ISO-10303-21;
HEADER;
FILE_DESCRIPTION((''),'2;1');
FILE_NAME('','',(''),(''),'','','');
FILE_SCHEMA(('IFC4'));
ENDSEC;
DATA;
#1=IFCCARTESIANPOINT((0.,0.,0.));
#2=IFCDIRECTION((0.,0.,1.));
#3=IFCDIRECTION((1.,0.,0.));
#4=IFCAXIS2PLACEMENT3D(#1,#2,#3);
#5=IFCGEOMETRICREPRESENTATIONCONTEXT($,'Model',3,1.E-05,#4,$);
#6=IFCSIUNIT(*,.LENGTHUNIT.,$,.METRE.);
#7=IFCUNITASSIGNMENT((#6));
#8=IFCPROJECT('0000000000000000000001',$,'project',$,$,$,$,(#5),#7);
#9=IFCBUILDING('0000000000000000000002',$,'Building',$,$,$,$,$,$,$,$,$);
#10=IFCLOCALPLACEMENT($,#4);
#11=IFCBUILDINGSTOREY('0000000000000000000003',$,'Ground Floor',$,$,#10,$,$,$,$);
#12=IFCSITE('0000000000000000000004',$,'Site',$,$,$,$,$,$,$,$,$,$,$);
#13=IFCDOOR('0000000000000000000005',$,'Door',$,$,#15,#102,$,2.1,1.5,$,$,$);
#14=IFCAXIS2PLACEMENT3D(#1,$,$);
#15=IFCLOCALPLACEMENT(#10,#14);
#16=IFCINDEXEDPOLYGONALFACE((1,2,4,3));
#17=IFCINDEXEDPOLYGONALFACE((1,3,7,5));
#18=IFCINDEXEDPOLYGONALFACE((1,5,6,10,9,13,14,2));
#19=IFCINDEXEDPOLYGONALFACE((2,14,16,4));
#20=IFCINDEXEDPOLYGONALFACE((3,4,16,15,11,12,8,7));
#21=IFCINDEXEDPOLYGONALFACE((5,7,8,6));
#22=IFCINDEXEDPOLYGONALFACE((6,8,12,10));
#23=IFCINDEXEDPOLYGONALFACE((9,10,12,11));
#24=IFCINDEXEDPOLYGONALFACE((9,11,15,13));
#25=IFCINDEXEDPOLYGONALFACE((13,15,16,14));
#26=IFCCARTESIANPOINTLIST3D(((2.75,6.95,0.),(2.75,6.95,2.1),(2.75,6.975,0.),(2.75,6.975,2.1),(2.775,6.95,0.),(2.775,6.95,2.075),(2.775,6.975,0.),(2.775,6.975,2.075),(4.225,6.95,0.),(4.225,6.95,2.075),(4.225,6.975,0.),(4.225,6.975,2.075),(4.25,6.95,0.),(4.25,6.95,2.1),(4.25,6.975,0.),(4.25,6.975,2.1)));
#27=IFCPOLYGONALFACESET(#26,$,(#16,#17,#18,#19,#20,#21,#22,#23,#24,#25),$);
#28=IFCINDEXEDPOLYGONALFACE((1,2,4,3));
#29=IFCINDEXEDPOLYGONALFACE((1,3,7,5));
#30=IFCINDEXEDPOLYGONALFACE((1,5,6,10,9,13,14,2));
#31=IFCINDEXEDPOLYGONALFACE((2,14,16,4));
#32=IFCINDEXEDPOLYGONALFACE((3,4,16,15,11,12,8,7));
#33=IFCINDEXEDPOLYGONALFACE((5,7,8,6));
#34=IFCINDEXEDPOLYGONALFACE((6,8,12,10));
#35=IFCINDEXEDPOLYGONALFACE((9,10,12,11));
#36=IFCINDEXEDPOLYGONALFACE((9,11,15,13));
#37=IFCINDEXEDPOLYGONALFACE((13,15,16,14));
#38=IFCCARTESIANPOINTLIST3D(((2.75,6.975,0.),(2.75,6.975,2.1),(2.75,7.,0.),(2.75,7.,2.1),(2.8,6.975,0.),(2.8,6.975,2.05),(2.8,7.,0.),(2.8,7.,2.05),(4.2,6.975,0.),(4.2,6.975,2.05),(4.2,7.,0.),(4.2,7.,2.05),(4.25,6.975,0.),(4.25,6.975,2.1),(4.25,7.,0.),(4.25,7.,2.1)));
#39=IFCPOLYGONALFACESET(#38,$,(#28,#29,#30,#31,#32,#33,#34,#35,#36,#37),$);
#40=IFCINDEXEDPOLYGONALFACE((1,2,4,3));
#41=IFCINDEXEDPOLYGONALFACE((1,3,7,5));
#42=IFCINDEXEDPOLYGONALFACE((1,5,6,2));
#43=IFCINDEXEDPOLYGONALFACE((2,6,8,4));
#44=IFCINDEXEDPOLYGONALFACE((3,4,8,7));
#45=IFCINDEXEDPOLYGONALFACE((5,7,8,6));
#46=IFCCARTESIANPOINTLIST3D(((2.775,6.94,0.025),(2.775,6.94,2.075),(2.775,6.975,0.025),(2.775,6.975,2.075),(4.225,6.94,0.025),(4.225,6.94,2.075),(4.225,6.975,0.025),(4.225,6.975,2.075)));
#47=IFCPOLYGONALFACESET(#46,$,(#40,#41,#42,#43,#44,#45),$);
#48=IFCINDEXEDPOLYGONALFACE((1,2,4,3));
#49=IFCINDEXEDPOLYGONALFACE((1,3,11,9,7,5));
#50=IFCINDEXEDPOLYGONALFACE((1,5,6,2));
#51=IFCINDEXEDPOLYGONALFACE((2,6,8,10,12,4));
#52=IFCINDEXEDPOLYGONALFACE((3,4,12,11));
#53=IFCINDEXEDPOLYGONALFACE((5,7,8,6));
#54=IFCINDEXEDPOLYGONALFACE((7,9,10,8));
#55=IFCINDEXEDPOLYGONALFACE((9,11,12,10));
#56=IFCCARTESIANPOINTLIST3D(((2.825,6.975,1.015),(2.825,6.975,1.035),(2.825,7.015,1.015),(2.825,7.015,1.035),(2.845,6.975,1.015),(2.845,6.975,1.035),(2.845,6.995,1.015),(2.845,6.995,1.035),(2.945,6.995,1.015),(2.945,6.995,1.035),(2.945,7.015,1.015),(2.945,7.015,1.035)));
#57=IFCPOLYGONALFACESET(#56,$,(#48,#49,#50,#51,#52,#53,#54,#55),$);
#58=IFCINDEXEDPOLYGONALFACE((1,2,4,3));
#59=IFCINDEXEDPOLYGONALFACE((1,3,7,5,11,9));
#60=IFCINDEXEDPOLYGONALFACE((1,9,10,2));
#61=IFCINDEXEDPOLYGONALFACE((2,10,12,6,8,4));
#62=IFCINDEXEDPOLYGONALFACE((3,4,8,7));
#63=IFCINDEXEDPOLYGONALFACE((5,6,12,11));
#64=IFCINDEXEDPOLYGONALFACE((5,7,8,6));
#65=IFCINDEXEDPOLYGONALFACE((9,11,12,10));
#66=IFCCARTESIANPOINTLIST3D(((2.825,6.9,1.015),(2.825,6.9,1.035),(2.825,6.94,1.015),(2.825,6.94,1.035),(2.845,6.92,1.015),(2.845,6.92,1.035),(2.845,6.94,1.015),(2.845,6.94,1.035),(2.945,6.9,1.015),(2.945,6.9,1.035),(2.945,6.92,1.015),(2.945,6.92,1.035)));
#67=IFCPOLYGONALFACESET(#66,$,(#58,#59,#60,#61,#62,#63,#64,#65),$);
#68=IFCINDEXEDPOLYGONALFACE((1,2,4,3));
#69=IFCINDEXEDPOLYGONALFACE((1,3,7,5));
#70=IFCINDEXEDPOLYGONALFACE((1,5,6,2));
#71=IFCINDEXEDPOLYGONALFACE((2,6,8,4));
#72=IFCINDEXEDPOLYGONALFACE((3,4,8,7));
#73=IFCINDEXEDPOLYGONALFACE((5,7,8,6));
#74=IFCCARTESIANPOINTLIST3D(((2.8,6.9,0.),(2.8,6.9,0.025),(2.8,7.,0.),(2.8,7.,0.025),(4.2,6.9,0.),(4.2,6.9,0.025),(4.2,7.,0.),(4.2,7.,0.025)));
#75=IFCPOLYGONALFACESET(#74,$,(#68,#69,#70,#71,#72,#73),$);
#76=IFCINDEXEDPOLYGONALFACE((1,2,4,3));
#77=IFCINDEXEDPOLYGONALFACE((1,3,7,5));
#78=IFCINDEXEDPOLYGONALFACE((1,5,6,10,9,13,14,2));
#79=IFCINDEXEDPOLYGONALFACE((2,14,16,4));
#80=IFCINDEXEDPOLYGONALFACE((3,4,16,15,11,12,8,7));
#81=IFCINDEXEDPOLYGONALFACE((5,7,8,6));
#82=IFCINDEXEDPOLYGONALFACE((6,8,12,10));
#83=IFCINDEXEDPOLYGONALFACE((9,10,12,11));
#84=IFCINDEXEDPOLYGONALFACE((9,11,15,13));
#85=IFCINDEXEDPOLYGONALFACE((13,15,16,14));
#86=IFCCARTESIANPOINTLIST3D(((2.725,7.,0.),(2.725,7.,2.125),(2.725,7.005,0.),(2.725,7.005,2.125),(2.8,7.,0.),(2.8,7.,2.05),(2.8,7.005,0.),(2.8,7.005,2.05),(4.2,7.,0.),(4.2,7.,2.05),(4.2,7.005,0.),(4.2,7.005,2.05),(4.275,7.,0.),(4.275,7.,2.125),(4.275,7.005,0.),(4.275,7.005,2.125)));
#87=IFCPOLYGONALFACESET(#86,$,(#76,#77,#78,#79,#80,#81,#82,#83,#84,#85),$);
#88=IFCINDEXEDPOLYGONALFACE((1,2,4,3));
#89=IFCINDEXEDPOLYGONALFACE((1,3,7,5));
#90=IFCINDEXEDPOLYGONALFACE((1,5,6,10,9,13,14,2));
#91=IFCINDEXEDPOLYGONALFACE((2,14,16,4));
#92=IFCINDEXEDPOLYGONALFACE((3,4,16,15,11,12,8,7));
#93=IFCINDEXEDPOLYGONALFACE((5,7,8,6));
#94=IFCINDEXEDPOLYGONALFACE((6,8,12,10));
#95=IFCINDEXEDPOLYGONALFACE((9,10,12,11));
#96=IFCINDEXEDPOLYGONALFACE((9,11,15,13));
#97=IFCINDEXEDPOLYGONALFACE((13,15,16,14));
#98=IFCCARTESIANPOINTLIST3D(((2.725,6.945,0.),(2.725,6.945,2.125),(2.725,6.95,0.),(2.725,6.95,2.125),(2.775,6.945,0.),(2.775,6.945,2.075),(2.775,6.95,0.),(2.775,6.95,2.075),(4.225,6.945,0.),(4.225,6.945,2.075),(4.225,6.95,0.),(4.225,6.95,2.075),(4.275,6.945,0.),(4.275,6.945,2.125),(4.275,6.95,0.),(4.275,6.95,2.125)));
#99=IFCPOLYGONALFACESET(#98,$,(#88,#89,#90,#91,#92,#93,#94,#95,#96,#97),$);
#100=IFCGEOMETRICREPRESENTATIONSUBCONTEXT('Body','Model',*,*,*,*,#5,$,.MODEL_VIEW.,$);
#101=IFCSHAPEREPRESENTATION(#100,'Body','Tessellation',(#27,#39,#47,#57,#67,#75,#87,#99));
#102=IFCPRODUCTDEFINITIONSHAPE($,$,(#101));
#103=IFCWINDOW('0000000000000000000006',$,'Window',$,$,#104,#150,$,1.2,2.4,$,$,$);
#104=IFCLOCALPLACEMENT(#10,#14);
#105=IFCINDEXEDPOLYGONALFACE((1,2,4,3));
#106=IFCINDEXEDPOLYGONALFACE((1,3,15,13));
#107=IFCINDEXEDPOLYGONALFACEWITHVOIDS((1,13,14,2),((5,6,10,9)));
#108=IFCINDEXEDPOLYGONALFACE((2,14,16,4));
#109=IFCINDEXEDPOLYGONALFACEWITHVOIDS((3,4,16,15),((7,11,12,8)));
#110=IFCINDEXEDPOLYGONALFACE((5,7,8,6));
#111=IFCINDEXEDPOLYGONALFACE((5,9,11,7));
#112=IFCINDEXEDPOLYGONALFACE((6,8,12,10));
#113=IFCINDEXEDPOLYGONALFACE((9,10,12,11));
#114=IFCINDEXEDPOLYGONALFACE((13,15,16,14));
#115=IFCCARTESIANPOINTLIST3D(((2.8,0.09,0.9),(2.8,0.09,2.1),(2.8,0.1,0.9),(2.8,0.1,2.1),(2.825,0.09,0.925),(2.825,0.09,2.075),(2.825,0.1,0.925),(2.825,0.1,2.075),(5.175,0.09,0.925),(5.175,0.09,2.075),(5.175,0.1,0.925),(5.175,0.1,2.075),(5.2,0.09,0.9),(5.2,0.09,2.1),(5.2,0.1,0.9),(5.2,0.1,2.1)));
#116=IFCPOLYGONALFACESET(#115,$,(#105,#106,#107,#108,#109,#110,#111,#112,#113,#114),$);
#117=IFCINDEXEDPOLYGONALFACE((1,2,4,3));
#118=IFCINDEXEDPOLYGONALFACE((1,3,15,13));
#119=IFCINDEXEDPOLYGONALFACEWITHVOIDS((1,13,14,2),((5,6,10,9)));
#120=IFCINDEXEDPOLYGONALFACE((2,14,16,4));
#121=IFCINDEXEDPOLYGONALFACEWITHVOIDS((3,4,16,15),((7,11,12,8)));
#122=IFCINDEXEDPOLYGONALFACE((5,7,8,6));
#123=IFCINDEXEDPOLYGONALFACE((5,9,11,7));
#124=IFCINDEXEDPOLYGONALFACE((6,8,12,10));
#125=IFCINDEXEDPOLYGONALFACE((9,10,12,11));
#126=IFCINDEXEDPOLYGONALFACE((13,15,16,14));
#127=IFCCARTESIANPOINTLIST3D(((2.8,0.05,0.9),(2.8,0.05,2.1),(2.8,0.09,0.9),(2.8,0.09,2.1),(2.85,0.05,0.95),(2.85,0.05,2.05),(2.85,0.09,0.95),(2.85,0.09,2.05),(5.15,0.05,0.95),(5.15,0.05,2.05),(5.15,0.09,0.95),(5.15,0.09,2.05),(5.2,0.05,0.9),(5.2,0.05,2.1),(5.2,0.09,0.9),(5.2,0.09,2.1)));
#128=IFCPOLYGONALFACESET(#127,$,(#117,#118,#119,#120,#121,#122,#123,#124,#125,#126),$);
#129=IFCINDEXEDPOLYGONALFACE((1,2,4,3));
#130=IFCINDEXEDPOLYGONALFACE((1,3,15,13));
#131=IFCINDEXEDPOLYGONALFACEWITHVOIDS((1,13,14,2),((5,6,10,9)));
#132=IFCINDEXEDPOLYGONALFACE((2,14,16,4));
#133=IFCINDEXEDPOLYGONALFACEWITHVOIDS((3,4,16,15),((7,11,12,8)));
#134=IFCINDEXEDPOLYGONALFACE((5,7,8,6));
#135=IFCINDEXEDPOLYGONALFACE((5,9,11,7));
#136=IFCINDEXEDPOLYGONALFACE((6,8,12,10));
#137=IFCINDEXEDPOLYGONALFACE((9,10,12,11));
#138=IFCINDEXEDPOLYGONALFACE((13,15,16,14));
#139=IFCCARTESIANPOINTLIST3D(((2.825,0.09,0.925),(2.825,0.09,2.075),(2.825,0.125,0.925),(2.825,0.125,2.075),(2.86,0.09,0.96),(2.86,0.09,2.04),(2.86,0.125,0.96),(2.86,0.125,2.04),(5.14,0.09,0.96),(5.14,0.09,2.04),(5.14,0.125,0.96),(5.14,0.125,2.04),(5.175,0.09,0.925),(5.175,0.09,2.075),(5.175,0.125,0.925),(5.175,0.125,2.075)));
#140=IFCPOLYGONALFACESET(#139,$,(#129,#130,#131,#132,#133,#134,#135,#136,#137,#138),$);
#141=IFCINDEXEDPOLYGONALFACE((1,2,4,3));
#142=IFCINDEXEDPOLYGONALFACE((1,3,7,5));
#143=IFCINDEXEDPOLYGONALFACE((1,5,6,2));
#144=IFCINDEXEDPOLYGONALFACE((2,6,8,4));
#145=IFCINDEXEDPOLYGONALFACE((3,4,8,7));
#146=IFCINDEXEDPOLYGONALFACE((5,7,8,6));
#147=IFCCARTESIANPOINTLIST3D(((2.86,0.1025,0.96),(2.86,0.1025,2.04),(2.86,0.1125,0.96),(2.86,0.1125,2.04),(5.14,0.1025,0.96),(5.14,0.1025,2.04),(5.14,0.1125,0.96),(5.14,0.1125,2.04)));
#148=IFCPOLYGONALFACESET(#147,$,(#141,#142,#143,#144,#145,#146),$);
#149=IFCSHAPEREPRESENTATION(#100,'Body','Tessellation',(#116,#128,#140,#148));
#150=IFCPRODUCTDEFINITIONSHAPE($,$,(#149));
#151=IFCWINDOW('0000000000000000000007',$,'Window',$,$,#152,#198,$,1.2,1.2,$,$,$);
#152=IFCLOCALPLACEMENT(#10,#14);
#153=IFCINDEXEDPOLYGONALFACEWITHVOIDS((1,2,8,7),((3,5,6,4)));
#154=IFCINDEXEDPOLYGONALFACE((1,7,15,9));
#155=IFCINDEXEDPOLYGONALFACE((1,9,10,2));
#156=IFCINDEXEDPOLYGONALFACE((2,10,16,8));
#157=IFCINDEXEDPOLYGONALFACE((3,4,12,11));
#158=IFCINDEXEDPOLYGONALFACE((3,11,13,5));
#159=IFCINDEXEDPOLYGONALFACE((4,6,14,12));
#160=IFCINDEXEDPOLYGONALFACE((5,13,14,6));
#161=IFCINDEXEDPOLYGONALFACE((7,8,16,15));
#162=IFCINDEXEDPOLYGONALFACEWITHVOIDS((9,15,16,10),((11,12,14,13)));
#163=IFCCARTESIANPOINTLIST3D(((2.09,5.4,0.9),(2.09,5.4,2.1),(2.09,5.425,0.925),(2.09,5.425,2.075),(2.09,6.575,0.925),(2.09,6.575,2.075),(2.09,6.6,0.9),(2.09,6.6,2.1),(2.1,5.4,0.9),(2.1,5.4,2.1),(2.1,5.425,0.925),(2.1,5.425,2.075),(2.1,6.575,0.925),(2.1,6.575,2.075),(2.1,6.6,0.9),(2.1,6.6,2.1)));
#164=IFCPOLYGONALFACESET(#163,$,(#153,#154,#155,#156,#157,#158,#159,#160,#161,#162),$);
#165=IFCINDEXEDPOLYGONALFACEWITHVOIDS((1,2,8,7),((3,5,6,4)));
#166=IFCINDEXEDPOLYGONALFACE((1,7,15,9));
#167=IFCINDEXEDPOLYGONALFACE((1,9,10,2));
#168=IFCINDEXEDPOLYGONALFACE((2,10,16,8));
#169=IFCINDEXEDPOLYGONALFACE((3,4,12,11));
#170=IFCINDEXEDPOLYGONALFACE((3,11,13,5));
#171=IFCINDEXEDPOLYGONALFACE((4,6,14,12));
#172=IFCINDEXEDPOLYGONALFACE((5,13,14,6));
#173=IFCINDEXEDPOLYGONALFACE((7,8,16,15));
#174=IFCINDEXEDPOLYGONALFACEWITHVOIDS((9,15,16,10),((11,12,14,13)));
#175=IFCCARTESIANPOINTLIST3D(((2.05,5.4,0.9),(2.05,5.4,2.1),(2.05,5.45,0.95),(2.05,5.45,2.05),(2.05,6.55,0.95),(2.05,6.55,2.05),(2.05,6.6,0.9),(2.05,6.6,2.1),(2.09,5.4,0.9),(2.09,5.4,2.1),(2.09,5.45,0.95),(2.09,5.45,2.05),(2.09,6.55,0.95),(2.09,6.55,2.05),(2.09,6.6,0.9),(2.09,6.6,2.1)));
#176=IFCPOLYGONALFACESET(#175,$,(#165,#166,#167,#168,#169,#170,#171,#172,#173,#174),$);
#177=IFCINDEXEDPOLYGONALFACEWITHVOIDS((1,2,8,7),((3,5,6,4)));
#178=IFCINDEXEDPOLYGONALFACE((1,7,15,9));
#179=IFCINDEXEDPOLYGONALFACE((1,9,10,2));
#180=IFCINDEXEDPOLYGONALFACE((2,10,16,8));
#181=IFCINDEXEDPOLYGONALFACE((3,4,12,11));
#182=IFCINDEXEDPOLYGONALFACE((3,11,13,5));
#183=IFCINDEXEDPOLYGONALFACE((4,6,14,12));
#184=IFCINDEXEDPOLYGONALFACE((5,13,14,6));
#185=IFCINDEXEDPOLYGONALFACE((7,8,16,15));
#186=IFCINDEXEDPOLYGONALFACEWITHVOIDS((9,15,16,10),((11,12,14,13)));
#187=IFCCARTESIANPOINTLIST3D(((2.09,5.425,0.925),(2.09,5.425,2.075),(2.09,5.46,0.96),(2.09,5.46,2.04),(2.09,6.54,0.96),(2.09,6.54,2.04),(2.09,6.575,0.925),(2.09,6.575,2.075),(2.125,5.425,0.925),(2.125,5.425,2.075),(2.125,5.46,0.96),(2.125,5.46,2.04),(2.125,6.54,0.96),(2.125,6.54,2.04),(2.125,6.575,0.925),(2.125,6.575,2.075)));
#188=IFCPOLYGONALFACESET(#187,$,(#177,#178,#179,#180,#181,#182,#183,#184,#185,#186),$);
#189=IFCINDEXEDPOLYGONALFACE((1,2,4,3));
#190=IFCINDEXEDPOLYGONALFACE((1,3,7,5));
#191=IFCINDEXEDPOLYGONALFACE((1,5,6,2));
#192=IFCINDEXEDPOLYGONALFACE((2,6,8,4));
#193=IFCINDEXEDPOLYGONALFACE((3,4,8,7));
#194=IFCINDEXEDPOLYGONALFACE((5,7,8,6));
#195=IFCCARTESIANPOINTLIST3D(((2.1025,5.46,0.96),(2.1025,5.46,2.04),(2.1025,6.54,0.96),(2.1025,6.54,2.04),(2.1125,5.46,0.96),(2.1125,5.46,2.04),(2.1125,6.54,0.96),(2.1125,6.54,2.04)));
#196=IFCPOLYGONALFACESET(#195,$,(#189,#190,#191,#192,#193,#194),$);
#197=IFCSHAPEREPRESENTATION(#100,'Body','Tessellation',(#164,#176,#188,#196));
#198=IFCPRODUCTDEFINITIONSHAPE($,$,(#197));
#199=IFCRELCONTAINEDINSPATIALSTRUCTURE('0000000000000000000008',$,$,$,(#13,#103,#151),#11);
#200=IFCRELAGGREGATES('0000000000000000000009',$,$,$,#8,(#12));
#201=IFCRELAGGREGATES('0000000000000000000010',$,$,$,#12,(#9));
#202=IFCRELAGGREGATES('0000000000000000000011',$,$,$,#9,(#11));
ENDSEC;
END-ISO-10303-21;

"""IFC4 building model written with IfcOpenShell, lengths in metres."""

from ifc_helpers import new_model, si_unit, frame, origin_with_axes, place, context, subcontext, project, spatial, line, indexed_curve, outline, extrude, element, save


model = new_model("IFC4")

# Units and contexts
model_context = context("Model", 3, precision=1e-05, world=origin_with_axes())
body_context = subcontext(model_context, "Body", "Model", "MODEL_VIEW")
ifc_project = project(units=[si_unit("LENGTHUNIT", "METRE")], contexts=[model_context])

# Site, building, storey
site = spatial("IfcSite", under=ifc_project, Name="Site")
building = spatial("IfcBuilding", under=site, Name="Building")
storey_placement = place(None, origin_with_axes())
storey = spatial("IfcBuildingStorey", under=building, at=storey_placement, Name="Ground Floor")

# Door
door_1_placement = place(storey_placement, frame((4.25, 7.0, 0.0), z_axis=(0.0, 0.0, 1.0), x_axis=(-1.0, 0.0, 0.0)))
element("IfcDoor", 1, at=door_1_placement, inside=storey, Name="Door", OverallHeight=2.1, OverallWidth=1.5, context=body_context, shape_type="SweptSolid", body=[
    extrude(outline(indexed_curve([(0.0, 0.0), (0.0, 2.1), (1.5, 2.1), (1.5, 0.0), (1.475, 0.0), (1.475, 2.075), (0.025, 2.075), (0.025, 0.0)], segments=[line(1, 2, 3, 4, 5, 6, 7, 8, 1)])), frame((0.0, 0.025, 0.0), z_axis=(0.0, -1.0, 0.0), x_axis=(1.0, 0.0, 0.0)), (0.0, 0.0, -1.0), 0.025),
    extrude(outline(indexed_curve([(0.0, 0.0), (0.0, 2.1), (1.5, 2.1), (1.5, 0.0), (1.45, 0.0), (1.45, 2.05), (0.05, 2.05), (0.05, 0.0)], segments=[line(1, 2, 3, 4, 5, 6, 7, 8, 1)])), frame((0.0, 0.0, 0.0), z_axis=(0.0, -1.0, 0.0), x_axis=(1.0, 0.0, 0.0)), (0.0, 0.0, -1.0), 0.025),
    extrude(outline(indexed_curve([(0.0, 0.0), (1.45, 0.0), (1.45, 0.035), (0.0, 0.035)], segments=[line(1, 2, 3, 4, 1)])), frame((0.025, 0.025, 0.025), z_axis=(0.0, 0.0, 1.0), x_axis=(1.0, 0.0, 0.0)), (0.0, 0.0, 1.0), 2.05),
    extrude(outline(indexed_curve([(0.0, 0.0), (0.0, -0.04), (-0.12, -0.04), (-0.12, -0.02), (-0.02, -0.02), (-0.02, 0.0)], segments=[line(1, 2, 3, 4, 5, 6, 1)])), frame((1.425, 0.025, 1.015), z_axis=(0.0, 0.0, 1.0), x_axis=(1.0, 0.0, 0.0)), (0.0, 0.0, 1.0), 0.02),
    extrude(outline(indexed_curve([(0.0, 0.0), (0.0, 0.04), (-0.12, 0.04), (-0.12, 0.02), (-0.02, 0.02), (-0.02, 0.0)], segments=[line(1, 2, 3, 4, 5, 6, 1)])), frame((1.425, 0.06, 1.015), z_axis=(0.0, 0.0, 1.0), x_axis=(1.0, 0.0, 0.0)), (0.0, 0.0, 1.0), 0.02),
    extrude(outline(indexed_curve([(0.0, 0.0), (1.4, 0.0), (1.4, 0.1), (0.0, 0.1)], segments=[line(1, 2, 3, 4, 1)])), frame((0.05, 0.0, 0.0), z_axis=(0.0, 0.0, 1.0), x_axis=(1.0, 0.0, 0.0)), (0.0, 0.0, 1.0), 0.025),
    extrude(outline(indexed_curve([(0.0, 0.0), (0.0, 2.125), (1.55, 2.125), (1.55, 0.0), (1.475, 0.0), (1.475, 2.05), (0.075, 2.05), (0.075, 0.0)], segments=[line(1, 2, 3, 4, 5, 6, 7, 8, 1)])), frame((-0.025, -0.005, 0.0), z_axis=(0.0, -1.0, 0.0), x_axis=(1.0, 0.0, 0.0)), (0.0, 0.0, -1.0), 0.005),
    extrude(outline(indexed_curve([(0.0, 0.0), (0.0, 2.125), (1.55, 2.125), (1.55, 0.0), (1.5, 0.0), (1.5, 2.075), (0.05, 2.075), (0.05, 0.0)], segments=[line(1, 2, 3, 4, 5, 6, 7, 8, 1)])), frame((-0.025, 0.05, 0.0), z_axis=(0.0, -1.0, 0.0), x_axis=(1.0, 0.0, 0.0)), (0.0, 0.0, -1.0), 0.005),
])

# Windows
window_1_placement = place(storey_placement, frame((2.8, 0.0, 0.9), z_axis=(0.0, 0.0, 1.0), x_axis=(1.0, 0.0, 0.0)))
element("IfcWindow", 2, at=window_1_placement, inside=storey, Name="Window", OverallHeight=1.2, OverallWidth=2.4, context=body_context, shape_type="SweptSolid", body=[
    extrude(outline(indexed_curve([(0.0, 0.0), (2.4, 0.0), (2.4, 1.2), (0.0, 1.2)], segments=[line(1, 2, 3, 4, 1)]), holes=[indexed_curve([(0.025, 0.025), (2.375, 0.025), (2.375, 1.175), (0.025, 1.175)], segments=[line(1, 2, 3, 4, 1)])]), frame((0.0, 0.09, 0.0), z_axis=(0.0, -1.0, 0.0), x_axis=(1.0, 0.0, 0.0)), (0.0, 0.0, -1.0), 0.01),
    extrude(outline(indexed_curve([(0.0, 0.0), (2.4, 0.0), (2.4, 1.2), (0.0, 1.2)], segments=[line(1, 2, 3, 4, 1)]), holes=[indexed_curve([(0.05, 0.05), (2.35, 0.05), (2.35, 1.15), (0.05, 1.15)], segments=[line(1, 2, 3, 4, 1)])]), frame((0.0, 0.05, 0.0), z_axis=(0.0, -1.0, 0.0), x_axis=(1.0, 0.0, 0.0)), (0.0, 0.0, -1.0), 0.04),
    extrude(outline(indexed_curve([(0.0, 0.0), (2.35, 0.0), (2.35, 1.15), (0.0, 1.15)], segments=[line(1, 2, 3, 4, 1)]), holes=[indexed_curve([(0.035, 0.035), (2.315, 0.035), (2.315, 1.115), (0.035, 1.115)], segments=[line(1, 2, 3, 4, 1)])]), frame((0.025, 0.09, 0.025), z_axis=(0.0, -1.0, 0.0), x_axis=(1.0, 0.0, 0.0)), (0.0, 0.0, -1.0), 0.035),
    extrude(outline(indexed_curve([(0.035, 0.035), (2.315, 0.035), (2.315, 1.115), (0.035, 1.115)], segments=[line(1, 2, 3, 4, 1)])), frame((0.025, 0.1025, 0.025), z_axis=(0.0, -1.0, 0.0), x_axis=(1.0, 0.0, 0.0)), (0.0, 0.0, -1.0), 0.01),
])
window_2_placement = place(storey_placement, frame((2.0, 6.6, 0.9), z_axis=(0.0, 0.0, 1.0), x_axis=(0.0, -1.0, 0.0)))
element("IfcWindow", 3, at=window_2_placement, inside=storey, Name="Window", OverallHeight=1.2, OverallWidth=1.2, context=body_context, shape_type="SweptSolid", body=[
    extrude(outline(indexed_curve([(0.0, 0.0), (1.2, 0.0), (1.2, 1.2), (0.0, 1.2)], segments=[line(1, 2, 3, 4, 1)]), holes=[indexed_curve([(0.025, 0.025), (1.175, 0.025), (1.175, 1.175), (0.025, 1.175)], segments=[line(1, 2, 3, 4, 1)])]), frame((0.0, 0.09, 0.0), z_axis=(0.0, -1.0, 0.0), x_axis=(1.0, 0.0, 0.0)), (0.0, 0.0, -1.0), 0.01),
    extrude(outline(indexed_curve([(0.0, 0.0), (1.2, 0.0), (1.2, 1.2), (0.0, 1.2)], segments=[line(1, 2, 3, 4, 1)]), holes=[indexed_curve([(0.05, 0.05), (1.15, 0.05), (1.15, 1.15), (0.05, 1.15)], segments=[line(1, 2, 3, 4, 1)])]), frame((0.0, 0.05, 0.0), z_axis=(0.0, -1.0, 0.0), x_axis=(1.0, 0.0, 0.0)), (0.0, 0.0, -1.0), 0.04),
    extrude(outline(indexed_curve([(0.0, 0.0), (1.15, 0.0), (1.15, 1.15), (0.0, 1.15)], segments=[line(1, 2, 3, 4, 1)]), holes=[indexed_curve([(0.035, 0.035), (1.115, 0.035), (1.115, 1.115), (0.035, 1.115)], segments=[line(1, 2, 3, 4, 1)])]), frame((0.025, 0.09, 0.025), z_axis=(0.0, -1.0, 0.0), x_axis=(1.0, 0.0, 0.0)), (0.0, 0.0, -1.0), 0.035),
    extrude(outline(indexed_curve([(0.035, 0.035), (1.115, 0.035), (1.115, 1.115), (0.035, 1.115)], segments=[line(1, 2, 3, 4, 1)])), frame((0.025, 0.1025, 0.025), z_axis=(0.0, -1.0, 0.0), x_axis=(1.0, 0.0, 0.0)), (0.0, 0.0, -1.0), 0.01),
])

save(model, "model.ifc")
